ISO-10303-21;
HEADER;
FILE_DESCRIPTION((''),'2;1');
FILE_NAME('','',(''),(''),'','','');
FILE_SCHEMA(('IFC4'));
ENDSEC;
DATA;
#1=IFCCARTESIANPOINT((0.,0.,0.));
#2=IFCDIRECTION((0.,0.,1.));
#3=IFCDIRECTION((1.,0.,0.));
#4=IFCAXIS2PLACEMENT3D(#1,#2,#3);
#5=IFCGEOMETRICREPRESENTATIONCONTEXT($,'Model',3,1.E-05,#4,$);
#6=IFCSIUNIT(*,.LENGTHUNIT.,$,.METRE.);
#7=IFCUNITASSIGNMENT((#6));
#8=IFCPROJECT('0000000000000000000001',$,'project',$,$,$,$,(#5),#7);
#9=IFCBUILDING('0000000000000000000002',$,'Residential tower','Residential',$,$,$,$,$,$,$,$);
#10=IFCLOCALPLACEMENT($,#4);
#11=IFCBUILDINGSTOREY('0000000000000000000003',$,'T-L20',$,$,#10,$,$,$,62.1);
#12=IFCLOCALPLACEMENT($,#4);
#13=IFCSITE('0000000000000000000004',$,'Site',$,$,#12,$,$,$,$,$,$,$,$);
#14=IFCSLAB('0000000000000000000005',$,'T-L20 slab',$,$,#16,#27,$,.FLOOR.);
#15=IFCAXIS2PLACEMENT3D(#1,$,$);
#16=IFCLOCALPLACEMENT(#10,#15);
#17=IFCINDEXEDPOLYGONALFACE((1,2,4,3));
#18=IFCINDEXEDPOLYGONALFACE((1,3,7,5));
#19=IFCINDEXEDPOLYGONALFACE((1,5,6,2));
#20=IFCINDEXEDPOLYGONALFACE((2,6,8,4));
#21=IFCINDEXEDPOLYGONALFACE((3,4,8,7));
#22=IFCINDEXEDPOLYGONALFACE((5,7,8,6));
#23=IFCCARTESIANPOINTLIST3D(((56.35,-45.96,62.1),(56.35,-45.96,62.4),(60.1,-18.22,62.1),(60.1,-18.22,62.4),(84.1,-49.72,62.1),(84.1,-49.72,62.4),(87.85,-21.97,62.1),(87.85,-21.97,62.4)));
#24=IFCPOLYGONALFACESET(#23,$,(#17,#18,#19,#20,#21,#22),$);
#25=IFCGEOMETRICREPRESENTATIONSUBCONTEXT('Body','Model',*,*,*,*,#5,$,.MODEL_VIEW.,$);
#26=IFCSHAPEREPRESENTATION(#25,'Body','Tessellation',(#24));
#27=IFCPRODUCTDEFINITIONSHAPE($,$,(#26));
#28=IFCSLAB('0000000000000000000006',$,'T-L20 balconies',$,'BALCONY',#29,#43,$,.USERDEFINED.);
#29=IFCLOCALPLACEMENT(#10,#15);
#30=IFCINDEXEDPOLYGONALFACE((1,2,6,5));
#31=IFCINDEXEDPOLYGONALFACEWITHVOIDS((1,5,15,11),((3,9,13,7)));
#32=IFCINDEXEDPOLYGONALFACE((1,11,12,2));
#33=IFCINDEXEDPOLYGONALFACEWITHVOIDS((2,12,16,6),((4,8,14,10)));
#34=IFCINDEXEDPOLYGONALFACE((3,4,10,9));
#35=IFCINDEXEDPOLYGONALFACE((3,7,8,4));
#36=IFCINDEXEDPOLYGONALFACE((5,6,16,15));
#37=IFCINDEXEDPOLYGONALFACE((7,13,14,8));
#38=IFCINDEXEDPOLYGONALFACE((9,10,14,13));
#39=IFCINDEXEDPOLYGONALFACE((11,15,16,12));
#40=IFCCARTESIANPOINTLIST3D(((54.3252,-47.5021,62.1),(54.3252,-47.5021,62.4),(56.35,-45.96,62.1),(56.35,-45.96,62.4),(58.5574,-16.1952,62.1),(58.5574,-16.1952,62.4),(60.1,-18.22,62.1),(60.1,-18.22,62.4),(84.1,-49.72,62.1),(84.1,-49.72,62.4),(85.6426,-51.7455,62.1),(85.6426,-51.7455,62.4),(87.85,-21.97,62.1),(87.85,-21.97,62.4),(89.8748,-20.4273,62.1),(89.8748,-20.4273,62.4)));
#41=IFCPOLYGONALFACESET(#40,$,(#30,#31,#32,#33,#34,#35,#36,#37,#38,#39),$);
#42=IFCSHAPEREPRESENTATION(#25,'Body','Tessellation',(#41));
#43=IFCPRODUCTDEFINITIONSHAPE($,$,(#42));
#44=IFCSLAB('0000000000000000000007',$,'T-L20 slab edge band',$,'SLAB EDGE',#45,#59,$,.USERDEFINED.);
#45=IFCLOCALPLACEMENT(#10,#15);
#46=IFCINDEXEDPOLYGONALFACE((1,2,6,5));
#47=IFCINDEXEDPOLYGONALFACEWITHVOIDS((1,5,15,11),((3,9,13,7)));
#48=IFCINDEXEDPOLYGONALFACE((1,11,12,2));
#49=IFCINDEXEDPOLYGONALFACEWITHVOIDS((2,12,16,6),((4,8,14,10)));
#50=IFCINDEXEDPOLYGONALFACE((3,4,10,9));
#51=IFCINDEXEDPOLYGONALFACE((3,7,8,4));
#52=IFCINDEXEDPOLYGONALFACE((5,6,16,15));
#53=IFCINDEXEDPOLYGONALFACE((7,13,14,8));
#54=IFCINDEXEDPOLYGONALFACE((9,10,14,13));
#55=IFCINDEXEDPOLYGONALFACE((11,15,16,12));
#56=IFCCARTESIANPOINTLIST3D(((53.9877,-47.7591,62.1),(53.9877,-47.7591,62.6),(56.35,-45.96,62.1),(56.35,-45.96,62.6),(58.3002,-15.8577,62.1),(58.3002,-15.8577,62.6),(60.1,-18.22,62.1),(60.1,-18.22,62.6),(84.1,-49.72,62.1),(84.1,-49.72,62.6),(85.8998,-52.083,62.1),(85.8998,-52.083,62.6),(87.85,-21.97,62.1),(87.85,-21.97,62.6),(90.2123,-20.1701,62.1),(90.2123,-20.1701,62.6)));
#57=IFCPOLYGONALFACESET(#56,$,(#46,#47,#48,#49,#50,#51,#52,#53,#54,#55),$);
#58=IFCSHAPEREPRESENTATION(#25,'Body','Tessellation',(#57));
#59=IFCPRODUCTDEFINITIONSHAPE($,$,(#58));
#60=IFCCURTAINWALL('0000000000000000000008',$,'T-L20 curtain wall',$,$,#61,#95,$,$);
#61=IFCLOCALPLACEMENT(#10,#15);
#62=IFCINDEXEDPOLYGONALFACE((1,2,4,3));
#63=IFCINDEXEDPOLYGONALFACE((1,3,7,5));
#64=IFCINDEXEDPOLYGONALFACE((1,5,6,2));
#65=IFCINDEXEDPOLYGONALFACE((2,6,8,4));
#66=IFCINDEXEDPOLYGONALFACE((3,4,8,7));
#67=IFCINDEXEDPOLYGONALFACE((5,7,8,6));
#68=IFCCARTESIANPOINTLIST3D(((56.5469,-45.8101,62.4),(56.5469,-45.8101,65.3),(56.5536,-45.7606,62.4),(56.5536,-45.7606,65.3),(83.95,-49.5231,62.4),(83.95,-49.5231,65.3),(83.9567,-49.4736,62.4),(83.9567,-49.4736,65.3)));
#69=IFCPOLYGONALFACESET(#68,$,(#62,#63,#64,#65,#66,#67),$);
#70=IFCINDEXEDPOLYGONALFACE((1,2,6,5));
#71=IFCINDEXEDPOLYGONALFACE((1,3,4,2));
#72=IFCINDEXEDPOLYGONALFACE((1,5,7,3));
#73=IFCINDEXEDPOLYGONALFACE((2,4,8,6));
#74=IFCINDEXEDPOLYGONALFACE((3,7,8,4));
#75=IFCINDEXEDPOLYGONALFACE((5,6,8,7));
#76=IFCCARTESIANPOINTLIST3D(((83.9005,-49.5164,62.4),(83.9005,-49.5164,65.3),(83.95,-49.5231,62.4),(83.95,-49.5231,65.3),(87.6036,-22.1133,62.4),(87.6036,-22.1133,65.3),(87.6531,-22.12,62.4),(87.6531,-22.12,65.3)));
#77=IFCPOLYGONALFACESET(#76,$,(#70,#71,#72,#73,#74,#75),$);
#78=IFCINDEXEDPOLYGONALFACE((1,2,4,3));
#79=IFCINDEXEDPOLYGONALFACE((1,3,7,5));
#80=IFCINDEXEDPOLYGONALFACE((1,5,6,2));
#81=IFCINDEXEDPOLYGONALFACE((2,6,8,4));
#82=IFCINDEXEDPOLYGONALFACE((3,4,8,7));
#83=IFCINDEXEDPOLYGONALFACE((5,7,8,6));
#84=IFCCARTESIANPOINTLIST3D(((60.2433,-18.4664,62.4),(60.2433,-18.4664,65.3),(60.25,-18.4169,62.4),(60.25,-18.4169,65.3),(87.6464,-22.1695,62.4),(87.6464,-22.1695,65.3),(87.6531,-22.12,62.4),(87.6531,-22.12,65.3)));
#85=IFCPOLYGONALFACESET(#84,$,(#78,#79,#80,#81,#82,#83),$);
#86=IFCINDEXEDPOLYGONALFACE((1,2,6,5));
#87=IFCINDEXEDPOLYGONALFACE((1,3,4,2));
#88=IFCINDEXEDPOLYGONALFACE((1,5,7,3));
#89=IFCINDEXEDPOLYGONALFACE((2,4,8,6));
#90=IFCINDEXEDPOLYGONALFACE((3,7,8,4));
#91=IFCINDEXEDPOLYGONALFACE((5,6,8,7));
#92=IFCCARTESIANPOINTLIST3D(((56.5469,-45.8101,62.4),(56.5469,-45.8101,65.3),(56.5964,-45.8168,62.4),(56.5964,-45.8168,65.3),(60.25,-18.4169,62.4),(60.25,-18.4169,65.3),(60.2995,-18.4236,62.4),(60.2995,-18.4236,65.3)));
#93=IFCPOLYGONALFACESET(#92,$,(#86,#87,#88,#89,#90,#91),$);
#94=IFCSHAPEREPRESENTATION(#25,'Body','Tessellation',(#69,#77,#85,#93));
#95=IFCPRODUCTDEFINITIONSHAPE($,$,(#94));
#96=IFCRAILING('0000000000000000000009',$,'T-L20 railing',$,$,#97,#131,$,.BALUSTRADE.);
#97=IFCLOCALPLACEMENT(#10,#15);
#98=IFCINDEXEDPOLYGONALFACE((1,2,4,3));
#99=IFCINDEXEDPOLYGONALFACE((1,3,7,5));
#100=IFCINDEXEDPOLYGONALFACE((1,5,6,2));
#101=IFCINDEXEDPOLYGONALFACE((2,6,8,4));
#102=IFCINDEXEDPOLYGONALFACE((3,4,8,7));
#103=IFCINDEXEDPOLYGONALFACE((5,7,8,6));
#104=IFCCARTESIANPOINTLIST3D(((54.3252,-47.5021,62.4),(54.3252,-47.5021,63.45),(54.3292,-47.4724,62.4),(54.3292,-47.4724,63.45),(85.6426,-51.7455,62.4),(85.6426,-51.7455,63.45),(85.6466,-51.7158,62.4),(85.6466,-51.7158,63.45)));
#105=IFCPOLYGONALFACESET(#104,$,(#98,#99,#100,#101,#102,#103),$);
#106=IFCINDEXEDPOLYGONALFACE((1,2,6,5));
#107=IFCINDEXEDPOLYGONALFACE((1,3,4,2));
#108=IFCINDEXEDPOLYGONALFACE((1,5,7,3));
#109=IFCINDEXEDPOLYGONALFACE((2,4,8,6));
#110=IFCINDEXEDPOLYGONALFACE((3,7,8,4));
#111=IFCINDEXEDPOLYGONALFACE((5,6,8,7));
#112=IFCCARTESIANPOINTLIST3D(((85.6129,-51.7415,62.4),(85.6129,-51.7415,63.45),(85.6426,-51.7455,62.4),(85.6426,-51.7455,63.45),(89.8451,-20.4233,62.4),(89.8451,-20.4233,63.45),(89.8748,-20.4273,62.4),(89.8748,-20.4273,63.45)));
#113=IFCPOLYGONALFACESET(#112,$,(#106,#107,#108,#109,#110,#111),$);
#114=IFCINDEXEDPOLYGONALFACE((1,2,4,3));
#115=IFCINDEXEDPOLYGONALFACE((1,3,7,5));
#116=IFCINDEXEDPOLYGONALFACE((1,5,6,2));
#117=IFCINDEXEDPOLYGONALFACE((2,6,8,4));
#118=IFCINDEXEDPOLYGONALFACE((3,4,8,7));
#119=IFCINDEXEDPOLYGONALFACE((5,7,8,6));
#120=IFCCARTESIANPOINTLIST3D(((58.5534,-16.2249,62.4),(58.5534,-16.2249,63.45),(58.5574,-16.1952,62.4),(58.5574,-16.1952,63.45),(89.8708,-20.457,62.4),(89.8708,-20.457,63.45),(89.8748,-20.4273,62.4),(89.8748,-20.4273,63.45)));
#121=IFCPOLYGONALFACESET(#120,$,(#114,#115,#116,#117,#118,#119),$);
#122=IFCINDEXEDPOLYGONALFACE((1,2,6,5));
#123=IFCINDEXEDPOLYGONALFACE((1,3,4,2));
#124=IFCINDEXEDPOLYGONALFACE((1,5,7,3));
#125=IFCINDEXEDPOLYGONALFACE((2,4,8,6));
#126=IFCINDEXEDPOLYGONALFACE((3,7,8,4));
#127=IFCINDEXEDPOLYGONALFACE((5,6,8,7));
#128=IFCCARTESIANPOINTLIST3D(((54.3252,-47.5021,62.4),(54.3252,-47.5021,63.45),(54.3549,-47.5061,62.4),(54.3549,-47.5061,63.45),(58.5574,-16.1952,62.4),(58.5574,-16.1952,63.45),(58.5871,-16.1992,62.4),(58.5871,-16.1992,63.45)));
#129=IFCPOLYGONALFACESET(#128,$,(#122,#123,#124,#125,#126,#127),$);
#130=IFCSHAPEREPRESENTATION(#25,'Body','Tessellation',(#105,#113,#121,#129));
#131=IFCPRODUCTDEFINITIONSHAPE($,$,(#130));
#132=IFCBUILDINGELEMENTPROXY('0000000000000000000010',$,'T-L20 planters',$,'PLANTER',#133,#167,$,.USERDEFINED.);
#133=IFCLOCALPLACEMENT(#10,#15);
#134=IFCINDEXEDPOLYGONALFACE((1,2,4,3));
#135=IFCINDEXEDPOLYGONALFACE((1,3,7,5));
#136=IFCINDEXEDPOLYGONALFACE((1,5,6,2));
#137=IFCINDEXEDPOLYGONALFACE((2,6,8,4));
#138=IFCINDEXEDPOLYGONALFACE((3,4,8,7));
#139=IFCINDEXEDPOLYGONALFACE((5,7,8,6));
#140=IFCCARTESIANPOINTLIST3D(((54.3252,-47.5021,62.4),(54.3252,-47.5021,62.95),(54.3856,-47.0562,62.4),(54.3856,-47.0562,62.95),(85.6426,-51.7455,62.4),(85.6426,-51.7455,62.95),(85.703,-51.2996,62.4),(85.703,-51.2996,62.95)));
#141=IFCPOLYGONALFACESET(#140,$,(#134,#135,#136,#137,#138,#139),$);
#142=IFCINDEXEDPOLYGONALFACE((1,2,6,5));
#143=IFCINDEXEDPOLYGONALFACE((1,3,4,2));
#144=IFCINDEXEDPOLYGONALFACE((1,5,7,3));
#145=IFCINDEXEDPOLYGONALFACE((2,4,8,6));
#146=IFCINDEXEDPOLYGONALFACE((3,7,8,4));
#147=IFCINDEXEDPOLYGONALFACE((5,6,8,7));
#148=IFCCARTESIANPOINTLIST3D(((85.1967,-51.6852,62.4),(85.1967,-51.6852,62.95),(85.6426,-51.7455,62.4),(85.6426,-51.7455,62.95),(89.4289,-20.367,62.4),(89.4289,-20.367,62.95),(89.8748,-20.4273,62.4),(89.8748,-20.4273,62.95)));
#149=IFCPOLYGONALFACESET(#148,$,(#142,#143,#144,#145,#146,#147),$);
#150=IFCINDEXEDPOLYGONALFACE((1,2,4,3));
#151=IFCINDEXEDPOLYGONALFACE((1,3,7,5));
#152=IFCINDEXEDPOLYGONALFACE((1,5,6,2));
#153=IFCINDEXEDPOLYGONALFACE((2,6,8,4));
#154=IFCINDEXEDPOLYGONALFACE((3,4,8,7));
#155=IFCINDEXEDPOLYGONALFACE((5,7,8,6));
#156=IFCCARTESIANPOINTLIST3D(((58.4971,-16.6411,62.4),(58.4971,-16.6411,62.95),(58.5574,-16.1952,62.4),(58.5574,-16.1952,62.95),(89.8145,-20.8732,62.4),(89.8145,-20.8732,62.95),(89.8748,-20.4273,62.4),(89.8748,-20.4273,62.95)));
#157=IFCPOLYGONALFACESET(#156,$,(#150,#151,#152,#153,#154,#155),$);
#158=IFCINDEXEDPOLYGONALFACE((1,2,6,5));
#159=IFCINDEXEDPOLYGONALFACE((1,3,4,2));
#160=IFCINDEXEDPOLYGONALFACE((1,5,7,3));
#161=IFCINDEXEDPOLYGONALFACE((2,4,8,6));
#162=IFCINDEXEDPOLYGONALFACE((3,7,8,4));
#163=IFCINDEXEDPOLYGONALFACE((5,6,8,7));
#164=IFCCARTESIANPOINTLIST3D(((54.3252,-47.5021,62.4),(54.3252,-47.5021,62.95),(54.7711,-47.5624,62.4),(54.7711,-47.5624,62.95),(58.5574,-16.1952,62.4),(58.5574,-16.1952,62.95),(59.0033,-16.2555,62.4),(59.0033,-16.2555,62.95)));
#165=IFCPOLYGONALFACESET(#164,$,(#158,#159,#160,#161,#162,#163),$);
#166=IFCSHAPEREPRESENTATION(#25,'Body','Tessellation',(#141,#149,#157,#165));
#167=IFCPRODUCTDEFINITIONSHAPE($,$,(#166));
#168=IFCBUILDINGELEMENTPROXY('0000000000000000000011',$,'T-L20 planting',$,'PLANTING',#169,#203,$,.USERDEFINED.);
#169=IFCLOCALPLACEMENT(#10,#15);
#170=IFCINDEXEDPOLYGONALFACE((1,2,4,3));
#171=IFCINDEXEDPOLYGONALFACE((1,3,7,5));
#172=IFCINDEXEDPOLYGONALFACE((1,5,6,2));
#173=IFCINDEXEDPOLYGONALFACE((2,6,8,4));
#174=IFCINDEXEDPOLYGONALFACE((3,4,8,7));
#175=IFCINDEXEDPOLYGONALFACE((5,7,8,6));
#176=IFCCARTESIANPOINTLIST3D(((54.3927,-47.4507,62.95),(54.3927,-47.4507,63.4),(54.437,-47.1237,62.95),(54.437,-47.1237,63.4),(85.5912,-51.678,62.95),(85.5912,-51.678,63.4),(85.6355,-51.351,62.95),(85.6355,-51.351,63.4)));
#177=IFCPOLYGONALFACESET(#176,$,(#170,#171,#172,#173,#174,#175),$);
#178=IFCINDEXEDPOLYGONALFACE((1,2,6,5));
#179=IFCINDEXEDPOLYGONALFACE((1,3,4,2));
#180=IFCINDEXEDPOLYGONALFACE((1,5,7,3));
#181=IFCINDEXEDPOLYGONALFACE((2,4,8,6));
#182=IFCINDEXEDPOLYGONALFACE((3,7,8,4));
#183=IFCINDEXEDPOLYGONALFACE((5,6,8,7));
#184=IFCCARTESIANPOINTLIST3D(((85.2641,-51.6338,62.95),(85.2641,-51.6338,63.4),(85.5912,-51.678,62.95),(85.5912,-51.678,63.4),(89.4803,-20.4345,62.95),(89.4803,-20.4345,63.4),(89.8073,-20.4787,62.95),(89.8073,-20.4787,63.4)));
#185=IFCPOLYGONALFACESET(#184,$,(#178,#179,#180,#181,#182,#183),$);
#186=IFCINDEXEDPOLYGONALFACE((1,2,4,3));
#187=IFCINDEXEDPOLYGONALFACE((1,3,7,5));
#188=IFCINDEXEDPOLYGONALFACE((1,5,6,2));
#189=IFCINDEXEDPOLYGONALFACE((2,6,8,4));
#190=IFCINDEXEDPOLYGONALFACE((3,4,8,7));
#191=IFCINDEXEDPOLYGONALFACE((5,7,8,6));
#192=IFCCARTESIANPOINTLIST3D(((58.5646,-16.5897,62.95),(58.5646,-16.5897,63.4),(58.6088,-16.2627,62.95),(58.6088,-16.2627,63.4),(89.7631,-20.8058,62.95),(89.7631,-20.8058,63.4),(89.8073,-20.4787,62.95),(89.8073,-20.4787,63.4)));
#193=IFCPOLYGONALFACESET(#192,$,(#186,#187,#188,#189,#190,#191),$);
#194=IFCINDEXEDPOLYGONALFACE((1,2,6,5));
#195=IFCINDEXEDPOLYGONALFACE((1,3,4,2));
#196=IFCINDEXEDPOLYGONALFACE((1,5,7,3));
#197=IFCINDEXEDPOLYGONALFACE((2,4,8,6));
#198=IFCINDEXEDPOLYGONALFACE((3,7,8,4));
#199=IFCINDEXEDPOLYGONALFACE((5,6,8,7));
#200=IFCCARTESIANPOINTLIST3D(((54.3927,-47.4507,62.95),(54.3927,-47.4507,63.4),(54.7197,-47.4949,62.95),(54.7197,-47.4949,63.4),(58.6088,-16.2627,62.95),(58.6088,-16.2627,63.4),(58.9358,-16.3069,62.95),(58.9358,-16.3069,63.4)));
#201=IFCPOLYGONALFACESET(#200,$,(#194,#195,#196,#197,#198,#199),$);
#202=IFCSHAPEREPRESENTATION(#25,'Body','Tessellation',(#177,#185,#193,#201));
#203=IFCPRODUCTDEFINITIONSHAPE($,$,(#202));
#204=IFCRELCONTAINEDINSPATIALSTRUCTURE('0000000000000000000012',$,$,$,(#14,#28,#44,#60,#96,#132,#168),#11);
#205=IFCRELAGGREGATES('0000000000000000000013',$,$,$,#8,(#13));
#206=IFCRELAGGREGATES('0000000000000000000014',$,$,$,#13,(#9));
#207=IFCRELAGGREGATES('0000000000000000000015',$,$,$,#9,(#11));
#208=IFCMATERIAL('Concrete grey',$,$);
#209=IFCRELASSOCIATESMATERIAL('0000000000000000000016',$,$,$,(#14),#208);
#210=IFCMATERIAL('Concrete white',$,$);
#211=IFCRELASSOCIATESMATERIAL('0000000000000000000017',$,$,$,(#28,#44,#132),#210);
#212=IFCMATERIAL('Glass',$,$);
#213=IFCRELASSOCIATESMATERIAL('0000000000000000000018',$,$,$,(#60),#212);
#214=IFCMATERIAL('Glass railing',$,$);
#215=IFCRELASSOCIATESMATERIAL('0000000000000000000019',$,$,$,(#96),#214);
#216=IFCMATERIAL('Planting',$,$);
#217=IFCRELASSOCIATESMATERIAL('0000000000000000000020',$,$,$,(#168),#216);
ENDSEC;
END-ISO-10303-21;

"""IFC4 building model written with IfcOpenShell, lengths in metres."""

from ifc_helpers import new_model, si_unit, frame, origin_with_axes, place, context, subcontext, project, spatial, polyline, outline, extrude, material, element, save


model = new_model("IFC4")

# Units and contexts
model_context = context("Model", 3, precision=1e-05, world=origin_with_axes())
body_context = subcontext(model_context, "Body", "Model", "MODEL_VIEW")
ifc_project = project(units=[si_unit("LENGTHUNIT", "METRE")], contexts=[model_context])

# Site, building, storey
site_placement = place(None, origin_with_axes())
site = spatial("IfcSite", under=ifc_project, at=site_placement, Name="Site")
building = spatial("IfcBuilding", under=site, Name="Residential tower", Description="Residential")
storey_placement = place(None, origin_with_axes())
storey = spatial("IfcBuildingStorey", under=building, at=storey_placement, Name="T-L20", Elevation=62.1)

# Slabs
ifc_material_1 = material(Name="Concrete grey")
slab_1_placement = place(storey_placement, origin_with_axes())
element("IfcSlab", 1, at=slab_1_placement, inside=storey, material=ifc_material_1, Name="T-L20 slab", PredefinedType="FLOOR", context=body_context, shape_type="SweptSolid", body=[
    extrude(outline(polyline([(56.35, -45.96), (84.1, -49.72), (87.85, -21.97), (60.1, -18.22), (56.35, -45.96)])), frame((0.0, 0.0, 62.1), z_axis=(0.0, 0.0, 1.0), x_axis=(1.0, 0.0, 0.0)), (0.0, 0.0, 1.0), 0.3),
])
ifc_material_2 = material(Name="Concrete white")
slab_2_placement = place(storey_placement, origin_with_axes())
element("IfcSlab", 2, at=slab_2_placement, inside=storey, material=ifc_material_2, Name="T-L20 balconies", ObjectType="BALCONY", PredefinedType="USERDEFINED", context=body_context, shape_type="SweptSolid", body=[
    extrude(outline(polyline([(54.3252, -47.5021), (85.6426, -51.7455), (89.8748, -20.4273), (58.5574, -16.1952), (54.3252, -47.5021)]), holes=[polyline([(56.35, -45.96), (84.1, -49.72), (87.85, -21.97), (60.1, -18.22), (56.35, -45.96)])]), frame((0.0, 0.0, 62.1), z_axis=(0.0, 0.0, 1.0), x_axis=(1.0, 0.0, 0.0)), (0.0, 0.0, 1.0), 0.3),
])
slab_3_placement = place(storey_placement, origin_with_axes())
element("IfcSlab", 3, at=slab_3_placement, inside=storey, material=ifc_material_2, Name="T-L20 slab edge band", ObjectType="SLAB EDGE", PredefinedType="USERDEFINED", context=body_context, shape_type="SweptSolid", body=[
    extrude(outline(polyline([(53.9877, -47.7591), (85.8998, -52.083), (90.2123, -20.1701), (58.3002, -15.8577), (53.9877, -47.7591)]), holes=[polyline([(56.35, -45.96), (84.1, -49.72), (87.85, -21.97), (60.1, -18.22), (56.35, -45.96)])]), frame((0.0, 0.0, 62.1), z_axis=(0.0, 0.0, 1.0), x_axis=(1.0, 0.0, 0.0)), (0.0, 0.0, 1.0), 0.5),
])

# Curtain wall
ifc_material_3 = material(Name="Glass")
curtain_wall_placement = place(storey_placement, origin_with_axes())
element("IfcCurtainWall", 4, at=curtain_wall_placement, inside=storey, material=ifc_material_3, Name="T-L20 curtain wall", context=body_context, shape_type="SweptSolid", body=[
    extrude(outline(polyline([(56.5469, -45.8101), (83.95, -49.5231), (83.9567, -49.4736), (56.5536, -45.7606), (56.5469, -45.8101)])), frame((0.0, 0.0, 62.4), z_axis=(0.0, 0.0, 1.0), x_axis=(1.0, 0.0, 0.0)), (0.0, 0.0, 1.0), 2.9),
    extrude(outline(polyline([(83.95, -49.5231), (87.6531, -22.12), (87.6036, -22.1133), (83.9005, -49.5164), (83.95, -49.5231)])), frame((0.0, 0.0, 62.4), z_axis=(0.0, 0.0, 1.0), x_axis=(1.0, 0.0, 0.0)), (0.0, 0.0, 1.0), 2.9),
    extrude(outline(polyline([(87.6531, -22.12), (60.25, -18.4169), (60.2433, -18.4664), (87.6464, -22.1695), (87.6531, -22.12)])), frame((0.0, 0.0, 62.4), z_axis=(0.0, 0.0, 1.0), x_axis=(1.0, 0.0, 0.0)), (0.0, 0.0, 1.0), 2.9),
    extrude(outline(polyline([(60.25, -18.4169), (56.5469, -45.8101), (56.5964, -45.8168), (60.2995, -18.4236), (60.25, -18.4169)])), frame((0.0, 0.0, 62.4), z_axis=(0.0, 0.0, 1.0), x_axis=(1.0, 0.0, 0.0)), (0.0, 0.0, 1.0), 2.9),
])

# Railing
ifc_material_4 = material(Name="Glass railing")
railing_placement = place(storey_placement, origin_with_axes())
element("IfcRailing", 5, at=railing_placement, inside=storey, material=ifc_material_4, Name="T-L20 railing", PredefinedType="BALUSTRADE", context=body_context, shape_type="SweptSolid", body=[
    extrude(outline(polyline([(54.3252, -47.5021), (85.6426, -51.7455), (85.6466, -51.7158), (54.3292, -47.4724), (54.3252, -47.5021)])), frame((0.0, 0.0, 62.4), z_axis=(0.0, 0.0, 1.0), x_axis=(1.0, 0.0, 0.0)), (0.0, 0.0, 1.0), 1.05),
    extrude(outline(polyline([(85.6426, -51.7455), (89.8748, -20.4273), (89.8451, -20.4233), (85.6129, -51.7415), (85.6426, -51.7455)])), frame((0.0, 0.0, 62.4), z_axis=(0.0, 0.0, 1.0), x_axis=(1.0, 0.0, 0.0)), (0.0, 0.0, 1.0), 1.05),
    extrude(outline(polyline([(89.8748, -20.4273), (58.5574, -16.1952), (58.5534, -16.2249), (89.8708, -20.457), (89.8748, -20.4273)])), frame((0.0, 0.0, 62.4), z_axis=(0.0, 0.0, 1.0), x_axis=(1.0, 0.0, 0.0)), (0.0, 0.0, 1.0), 1.05),
    extrude(outline(polyline([(58.5574, -16.1952), (54.3252, -47.5021), (54.3549, -47.5061), (58.5871, -16.1992), (58.5574, -16.1952)])), frame((0.0, 0.0, 62.4), z_axis=(0.0, 0.0, 1.0), x_axis=(1.0, 0.0, 0.0)), (0.0, 0.0, 1.0), 1.05),
])

# Building element proxies
proxy_1_placement = place(storey_placement, origin_with_axes())
element("IfcBuildingElementProxy", 6, at=proxy_1_placement, inside=storey, material=ifc_material_2, Name="T-L20 planters", ObjectType="PLANTER", PredefinedType="USERDEFINED", context=body_context, shape_type="SweptSolid", body=[
    extrude(outline(polyline([(54.3252, -47.5021), (85.6426, -51.7455), (85.703, -51.2996), (54.3856, -47.0562), (54.3252, -47.5021)])), frame((0.0, 0.0, 62.4), z_axis=(0.0, 0.0, 1.0), x_axis=(1.0, 0.0, 0.0)), (0.0, 0.0, 1.0), 0.55),
    extrude(outline(polyline([(85.6426, -51.7455), (89.8748, -20.4273), (89.4289, -20.367), (85.1967, -51.6852), (85.6426, -51.7455)])), frame((0.0, 0.0, 62.4), z_axis=(0.0, 0.0, 1.0), x_axis=(1.0, 0.0, 0.0)), (0.0, 0.0, 1.0), 0.55),
    extrude(outline(polyline([(89.8748, -20.4273), (58.5574, -16.1952), (58.4971, -16.6411), (89.8145, -20.8732), (89.8748, -20.4273)])), frame((0.0, 0.0, 62.4), z_axis=(0.0, 0.0, 1.0), x_axis=(1.0, 0.0, 0.0)), (0.0, 0.0, 1.0), 0.55),
    extrude(outline(polyline([(58.5574, -16.1952), (54.3252, -47.5021), (54.7711, -47.5624), (59.0033, -16.2555), (58.5574, -16.1952)])), frame((0.0, 0.0, 62.4), z_axis=(0.0, 0.0, 1.0), x_axis=(1.0, 0.0, 0.0)), (0.0, 0.0, 1.0), 0.55),
])
ifc_material_5 = material(Name="Planting")
proxy_2_placement = place(storey_placement, origin_with_axes())
element("IfcBuildingElementProxy", 7, at=proxy_2_placement, inside=storey, material=ifc_material_5, Name="T-L20 planting", ObjectType="PLANTING", PredefinedType="USERDEFINED", context=body_context, shape_type="SweptSolid", body=[
    extrude(outline(polyline([(54.3927, -47.4507), (85.5912, -51.678), (85.6355, -51.351), (54.437, -47.1237), (54.3927, -47.4507)])), frame((0.0, 0.0, 62.95), z_axis=(0.0, 0.0, 1.0), x_axis=(1.0, 0.0, 0.0)), (0.0, 0.0, 1.0), 0.45),
    extrude(outline(polyline([(85.5912, -51.678), (89.8073, -20.4787), (89.4803, -20.4345), (85.2641, -51.6338), (85.5912, -51.678)])), frame((0.0, 0.0, 62.95), z_axis=(0.0, 0.0, 1.0), x_axis=(1.0, 0.0, 0.0)), (0.0, 0.0, 1.0), 0.45),
    extrude(outline(polyline([(89.8073, -20.4787), (58.6088, -16.2627), (58.5646, -16.5897), (89.7631, -20.8058), (89.8073, -20.4787)])), frame((0.0, 0.0, 62.95), z_axis=(0.0, 0.0, 1.0), x_axis=(1.0, 0.0, 0.0)), (0.0, 0.0, 1.0), 0.45),
    extrude(outline(polyline([(58.6088, -16.2627), (54.3927, -47.4507), (54.7197, -47.4949), (58.9358, -16.3069), (58.6088, -16.2627)])), frame((0.0, 0.0, 62.95), z_axis=(0.0, 0.0, 1.0), x_axis=(1.0, 0.0, 0.0)), (0.0, 0.0, 1.0), 0.45),
])

save(model, "model.ifc")
